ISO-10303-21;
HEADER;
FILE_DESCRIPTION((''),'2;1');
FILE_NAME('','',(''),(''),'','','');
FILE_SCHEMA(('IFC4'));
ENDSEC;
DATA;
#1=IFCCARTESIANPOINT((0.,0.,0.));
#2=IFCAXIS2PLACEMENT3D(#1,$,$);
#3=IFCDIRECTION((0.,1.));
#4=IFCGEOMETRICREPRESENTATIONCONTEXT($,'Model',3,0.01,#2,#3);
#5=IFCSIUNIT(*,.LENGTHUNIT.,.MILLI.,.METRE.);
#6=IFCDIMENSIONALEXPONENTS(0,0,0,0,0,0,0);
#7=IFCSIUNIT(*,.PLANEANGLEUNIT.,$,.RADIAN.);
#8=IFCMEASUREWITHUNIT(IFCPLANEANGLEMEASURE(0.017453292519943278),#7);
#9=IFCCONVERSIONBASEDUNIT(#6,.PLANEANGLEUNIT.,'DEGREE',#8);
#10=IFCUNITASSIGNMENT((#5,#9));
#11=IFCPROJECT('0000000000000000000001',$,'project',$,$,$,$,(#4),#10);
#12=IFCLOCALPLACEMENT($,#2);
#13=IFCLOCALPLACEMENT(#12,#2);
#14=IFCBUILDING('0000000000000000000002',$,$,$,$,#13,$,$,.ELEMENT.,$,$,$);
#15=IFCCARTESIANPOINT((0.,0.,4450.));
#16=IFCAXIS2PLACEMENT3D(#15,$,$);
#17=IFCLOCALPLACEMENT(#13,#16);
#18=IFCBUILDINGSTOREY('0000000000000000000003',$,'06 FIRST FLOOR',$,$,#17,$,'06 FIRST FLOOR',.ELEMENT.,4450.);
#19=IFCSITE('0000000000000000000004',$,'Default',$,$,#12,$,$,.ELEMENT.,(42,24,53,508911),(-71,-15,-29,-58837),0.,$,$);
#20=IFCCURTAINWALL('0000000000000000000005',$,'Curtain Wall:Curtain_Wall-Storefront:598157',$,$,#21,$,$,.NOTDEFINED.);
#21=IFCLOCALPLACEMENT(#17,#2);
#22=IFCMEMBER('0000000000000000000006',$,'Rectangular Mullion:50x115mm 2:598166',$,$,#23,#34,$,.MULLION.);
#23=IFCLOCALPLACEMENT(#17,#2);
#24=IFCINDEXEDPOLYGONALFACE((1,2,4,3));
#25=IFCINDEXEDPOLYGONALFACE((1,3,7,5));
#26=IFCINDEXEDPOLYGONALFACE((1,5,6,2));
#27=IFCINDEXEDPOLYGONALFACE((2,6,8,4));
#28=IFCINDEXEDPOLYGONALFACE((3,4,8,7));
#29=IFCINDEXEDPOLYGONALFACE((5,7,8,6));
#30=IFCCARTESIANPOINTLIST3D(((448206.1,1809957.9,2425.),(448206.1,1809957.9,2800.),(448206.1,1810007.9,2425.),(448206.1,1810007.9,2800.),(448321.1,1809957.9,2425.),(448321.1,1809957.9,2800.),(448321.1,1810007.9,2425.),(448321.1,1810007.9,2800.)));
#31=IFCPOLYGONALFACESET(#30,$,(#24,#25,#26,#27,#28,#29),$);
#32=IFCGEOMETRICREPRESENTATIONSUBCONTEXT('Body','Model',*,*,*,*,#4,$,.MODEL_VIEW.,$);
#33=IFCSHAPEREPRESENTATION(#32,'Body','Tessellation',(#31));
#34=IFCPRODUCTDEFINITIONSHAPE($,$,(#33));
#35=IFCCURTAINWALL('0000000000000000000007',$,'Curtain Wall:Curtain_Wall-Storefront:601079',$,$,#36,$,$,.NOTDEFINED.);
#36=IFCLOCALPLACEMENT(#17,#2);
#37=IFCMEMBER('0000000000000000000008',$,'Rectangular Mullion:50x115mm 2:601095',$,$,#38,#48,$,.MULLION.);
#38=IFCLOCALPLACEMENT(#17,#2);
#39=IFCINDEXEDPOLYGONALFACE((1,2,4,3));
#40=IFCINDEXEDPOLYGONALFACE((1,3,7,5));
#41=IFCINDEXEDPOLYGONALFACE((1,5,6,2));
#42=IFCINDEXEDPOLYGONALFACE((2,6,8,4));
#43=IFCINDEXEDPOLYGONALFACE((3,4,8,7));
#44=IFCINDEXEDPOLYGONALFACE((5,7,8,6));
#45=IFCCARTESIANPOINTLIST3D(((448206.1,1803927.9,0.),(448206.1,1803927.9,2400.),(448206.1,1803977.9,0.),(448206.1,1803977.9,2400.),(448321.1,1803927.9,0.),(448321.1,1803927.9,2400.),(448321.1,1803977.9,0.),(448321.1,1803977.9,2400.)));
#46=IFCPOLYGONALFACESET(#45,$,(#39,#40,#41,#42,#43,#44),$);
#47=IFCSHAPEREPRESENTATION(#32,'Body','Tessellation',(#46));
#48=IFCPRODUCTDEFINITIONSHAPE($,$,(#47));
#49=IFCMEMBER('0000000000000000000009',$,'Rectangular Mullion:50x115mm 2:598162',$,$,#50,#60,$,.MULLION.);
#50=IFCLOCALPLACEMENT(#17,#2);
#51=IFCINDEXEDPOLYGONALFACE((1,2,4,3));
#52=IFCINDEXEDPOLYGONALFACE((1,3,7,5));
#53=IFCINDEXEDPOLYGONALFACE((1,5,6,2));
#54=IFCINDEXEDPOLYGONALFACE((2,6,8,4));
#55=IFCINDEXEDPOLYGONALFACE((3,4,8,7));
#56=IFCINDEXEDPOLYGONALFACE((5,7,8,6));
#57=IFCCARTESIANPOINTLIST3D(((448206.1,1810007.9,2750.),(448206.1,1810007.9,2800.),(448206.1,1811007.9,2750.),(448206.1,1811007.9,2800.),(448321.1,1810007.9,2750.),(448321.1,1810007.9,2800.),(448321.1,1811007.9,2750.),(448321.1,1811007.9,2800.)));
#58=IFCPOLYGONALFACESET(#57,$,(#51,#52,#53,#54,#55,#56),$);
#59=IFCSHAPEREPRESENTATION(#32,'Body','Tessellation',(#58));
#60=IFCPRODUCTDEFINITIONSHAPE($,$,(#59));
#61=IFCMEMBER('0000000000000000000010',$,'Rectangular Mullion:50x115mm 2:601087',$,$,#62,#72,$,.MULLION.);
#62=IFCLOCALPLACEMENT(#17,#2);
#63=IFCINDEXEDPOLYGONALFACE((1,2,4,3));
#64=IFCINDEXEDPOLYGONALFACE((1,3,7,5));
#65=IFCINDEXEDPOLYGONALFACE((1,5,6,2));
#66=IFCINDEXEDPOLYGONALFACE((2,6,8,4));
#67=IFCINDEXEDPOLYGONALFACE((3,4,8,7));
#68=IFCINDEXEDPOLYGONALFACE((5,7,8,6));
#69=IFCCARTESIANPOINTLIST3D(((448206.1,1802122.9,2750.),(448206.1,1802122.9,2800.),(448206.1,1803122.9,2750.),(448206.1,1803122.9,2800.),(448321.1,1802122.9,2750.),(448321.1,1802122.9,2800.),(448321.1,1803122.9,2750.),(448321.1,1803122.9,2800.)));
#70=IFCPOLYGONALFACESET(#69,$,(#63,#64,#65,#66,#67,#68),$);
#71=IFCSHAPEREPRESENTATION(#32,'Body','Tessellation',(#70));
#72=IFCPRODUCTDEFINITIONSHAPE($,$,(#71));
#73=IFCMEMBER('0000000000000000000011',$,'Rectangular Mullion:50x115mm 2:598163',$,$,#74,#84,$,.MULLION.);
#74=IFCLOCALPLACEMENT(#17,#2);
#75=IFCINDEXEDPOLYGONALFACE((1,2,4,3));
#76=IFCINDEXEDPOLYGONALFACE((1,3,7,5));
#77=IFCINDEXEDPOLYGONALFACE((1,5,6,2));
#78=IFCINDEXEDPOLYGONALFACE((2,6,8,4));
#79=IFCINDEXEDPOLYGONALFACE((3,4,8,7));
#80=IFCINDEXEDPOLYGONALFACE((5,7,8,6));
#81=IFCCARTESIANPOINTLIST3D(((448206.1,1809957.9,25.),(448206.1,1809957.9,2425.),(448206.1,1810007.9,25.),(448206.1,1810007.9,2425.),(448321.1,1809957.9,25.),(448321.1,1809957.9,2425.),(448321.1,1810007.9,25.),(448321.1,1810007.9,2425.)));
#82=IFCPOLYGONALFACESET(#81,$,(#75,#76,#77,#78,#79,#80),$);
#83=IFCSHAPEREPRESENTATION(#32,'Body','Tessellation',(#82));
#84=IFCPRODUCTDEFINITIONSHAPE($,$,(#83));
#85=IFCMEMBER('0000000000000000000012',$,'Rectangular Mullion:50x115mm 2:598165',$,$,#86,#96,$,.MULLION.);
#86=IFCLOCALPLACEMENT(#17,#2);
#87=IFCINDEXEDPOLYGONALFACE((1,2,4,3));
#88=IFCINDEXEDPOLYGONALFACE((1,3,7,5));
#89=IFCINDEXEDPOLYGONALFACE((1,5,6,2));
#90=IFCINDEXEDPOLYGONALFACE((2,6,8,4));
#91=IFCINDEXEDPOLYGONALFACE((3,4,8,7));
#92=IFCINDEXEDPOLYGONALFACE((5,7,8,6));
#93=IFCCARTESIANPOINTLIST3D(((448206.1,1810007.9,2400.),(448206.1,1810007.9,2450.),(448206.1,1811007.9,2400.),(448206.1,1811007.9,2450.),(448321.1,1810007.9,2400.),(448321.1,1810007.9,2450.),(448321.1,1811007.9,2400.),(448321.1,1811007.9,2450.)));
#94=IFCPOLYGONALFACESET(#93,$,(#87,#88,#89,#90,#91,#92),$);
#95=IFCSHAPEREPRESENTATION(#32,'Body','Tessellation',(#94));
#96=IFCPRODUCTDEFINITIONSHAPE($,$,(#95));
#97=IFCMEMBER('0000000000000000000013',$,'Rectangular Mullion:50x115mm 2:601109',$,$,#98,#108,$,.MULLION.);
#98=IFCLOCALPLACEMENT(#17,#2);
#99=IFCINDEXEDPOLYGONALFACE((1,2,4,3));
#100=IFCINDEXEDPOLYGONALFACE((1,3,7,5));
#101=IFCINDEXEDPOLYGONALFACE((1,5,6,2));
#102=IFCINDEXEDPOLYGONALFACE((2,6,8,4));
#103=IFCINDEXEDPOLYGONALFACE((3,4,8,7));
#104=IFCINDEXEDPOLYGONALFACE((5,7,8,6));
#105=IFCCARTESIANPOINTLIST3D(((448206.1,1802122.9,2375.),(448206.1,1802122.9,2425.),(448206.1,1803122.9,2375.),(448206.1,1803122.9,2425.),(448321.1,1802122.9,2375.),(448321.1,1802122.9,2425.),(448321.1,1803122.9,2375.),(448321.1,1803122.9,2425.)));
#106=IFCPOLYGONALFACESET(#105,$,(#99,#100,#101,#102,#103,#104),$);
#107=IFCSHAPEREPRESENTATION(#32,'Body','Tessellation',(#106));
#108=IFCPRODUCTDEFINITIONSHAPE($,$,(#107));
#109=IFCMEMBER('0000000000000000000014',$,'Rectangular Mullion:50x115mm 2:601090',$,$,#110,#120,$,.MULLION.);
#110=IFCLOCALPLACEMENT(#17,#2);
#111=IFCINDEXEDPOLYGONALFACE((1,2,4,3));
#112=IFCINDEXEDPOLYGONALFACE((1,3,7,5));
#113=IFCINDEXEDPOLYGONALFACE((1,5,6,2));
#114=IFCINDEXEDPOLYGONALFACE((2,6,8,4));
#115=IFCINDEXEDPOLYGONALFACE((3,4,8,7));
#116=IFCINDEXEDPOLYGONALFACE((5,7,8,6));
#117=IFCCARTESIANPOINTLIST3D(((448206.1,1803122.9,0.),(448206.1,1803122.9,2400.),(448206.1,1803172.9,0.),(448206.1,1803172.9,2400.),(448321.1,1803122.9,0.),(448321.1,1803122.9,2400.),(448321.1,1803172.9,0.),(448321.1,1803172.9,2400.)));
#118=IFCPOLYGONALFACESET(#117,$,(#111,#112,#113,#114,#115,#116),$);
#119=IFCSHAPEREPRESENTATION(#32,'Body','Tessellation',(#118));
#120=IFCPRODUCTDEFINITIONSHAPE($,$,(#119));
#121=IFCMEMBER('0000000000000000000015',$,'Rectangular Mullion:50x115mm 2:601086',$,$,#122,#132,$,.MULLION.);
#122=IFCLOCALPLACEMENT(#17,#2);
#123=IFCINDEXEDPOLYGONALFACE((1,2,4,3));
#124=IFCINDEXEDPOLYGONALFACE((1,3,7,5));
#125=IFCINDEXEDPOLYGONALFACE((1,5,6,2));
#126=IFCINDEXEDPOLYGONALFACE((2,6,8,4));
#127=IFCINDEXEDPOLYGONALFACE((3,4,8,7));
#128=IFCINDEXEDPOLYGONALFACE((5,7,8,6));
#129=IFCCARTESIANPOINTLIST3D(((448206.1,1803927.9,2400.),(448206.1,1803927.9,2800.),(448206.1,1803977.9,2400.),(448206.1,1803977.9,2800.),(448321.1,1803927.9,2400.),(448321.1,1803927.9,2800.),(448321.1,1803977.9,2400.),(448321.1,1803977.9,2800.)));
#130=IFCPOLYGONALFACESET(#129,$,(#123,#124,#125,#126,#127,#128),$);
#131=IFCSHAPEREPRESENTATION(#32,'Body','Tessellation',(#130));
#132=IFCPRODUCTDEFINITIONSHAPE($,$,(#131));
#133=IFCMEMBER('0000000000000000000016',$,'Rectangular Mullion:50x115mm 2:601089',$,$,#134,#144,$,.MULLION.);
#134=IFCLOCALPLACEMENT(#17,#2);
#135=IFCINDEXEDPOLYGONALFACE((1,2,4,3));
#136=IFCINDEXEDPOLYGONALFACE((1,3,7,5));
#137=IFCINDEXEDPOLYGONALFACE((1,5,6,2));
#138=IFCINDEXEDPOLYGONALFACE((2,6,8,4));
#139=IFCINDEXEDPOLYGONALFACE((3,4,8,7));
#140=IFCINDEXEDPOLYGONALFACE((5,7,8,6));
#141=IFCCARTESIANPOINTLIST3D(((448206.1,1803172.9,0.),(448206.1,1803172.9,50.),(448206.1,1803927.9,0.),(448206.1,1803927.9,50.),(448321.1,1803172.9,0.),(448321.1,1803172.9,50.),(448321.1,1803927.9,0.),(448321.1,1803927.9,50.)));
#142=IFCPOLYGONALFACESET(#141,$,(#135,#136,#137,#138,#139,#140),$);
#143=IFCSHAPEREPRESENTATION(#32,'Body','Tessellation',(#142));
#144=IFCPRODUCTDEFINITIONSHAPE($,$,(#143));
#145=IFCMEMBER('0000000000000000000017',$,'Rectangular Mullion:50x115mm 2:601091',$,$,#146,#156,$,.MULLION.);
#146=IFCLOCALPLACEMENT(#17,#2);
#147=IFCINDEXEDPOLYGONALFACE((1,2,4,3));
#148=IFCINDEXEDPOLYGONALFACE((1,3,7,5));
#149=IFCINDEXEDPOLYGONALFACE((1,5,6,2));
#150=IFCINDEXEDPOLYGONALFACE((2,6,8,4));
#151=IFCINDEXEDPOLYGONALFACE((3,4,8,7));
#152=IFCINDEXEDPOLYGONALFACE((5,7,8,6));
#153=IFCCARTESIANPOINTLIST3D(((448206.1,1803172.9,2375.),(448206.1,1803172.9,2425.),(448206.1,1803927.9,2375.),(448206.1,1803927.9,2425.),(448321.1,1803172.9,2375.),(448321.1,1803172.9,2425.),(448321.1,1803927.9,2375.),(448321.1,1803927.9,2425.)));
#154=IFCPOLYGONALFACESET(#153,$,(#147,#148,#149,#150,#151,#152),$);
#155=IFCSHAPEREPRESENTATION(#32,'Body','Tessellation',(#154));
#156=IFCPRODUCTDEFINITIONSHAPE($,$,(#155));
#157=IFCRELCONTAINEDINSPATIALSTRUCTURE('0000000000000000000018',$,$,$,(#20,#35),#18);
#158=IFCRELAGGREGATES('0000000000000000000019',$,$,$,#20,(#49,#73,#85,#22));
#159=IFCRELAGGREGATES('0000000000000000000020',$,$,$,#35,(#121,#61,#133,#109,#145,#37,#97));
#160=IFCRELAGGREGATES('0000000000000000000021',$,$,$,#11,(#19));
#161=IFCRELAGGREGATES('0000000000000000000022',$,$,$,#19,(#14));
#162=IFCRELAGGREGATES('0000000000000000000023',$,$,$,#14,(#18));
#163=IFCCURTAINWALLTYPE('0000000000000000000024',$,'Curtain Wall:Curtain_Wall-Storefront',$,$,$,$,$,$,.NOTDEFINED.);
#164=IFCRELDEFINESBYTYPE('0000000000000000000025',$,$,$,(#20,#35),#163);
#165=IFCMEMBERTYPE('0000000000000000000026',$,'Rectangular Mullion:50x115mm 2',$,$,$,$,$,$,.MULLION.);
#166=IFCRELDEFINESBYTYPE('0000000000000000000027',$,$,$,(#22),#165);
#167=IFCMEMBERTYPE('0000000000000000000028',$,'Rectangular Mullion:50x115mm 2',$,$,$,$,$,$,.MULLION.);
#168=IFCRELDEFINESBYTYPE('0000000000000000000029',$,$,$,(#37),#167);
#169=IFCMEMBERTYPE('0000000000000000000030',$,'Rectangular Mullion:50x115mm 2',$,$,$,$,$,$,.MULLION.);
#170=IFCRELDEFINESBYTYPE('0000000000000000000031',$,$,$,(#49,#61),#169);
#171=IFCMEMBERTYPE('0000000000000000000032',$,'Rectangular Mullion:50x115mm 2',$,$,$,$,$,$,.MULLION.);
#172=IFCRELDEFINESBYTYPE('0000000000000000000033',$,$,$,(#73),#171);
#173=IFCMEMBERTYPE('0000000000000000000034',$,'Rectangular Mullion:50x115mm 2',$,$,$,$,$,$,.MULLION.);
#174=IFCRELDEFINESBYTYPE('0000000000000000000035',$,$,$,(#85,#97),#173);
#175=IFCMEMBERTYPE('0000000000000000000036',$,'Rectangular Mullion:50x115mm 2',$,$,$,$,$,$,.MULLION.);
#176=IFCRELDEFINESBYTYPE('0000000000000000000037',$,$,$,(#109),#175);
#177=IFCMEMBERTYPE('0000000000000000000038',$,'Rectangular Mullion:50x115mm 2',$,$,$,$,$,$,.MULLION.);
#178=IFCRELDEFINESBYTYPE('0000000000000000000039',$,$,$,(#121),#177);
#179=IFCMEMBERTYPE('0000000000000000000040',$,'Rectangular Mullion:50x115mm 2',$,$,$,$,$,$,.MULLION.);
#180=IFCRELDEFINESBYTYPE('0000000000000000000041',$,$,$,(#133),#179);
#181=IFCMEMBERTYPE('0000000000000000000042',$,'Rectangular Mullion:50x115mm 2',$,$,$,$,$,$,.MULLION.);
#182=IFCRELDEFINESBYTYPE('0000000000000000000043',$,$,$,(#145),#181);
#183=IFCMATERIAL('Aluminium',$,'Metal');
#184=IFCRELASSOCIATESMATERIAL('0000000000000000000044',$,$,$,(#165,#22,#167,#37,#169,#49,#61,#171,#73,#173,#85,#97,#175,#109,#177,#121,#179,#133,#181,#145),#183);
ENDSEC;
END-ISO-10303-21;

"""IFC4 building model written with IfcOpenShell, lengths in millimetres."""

from ifc_helpers import new_model, entity, si_unit, converted_unit, direction, frame, origin, place, context, subcontext, project, spatial, indexed_curve, outline, extrude, source, transform, mapped, material, type_object, type_shapes, element, aggregate, save


model = new_model("IFC4")

# Units and contexts
model_context = context("Model", 3, precision=0.01, world=origin(), true_north=direction((0.0, 1.0)))
body_context = subcontext(model_context, "Body", "Model", "MODEL_VIEW")
ifc_project = project(units=[si_unit("LENGTHUNIT", "METRE", prefix="MILLI"), converted_unit("PLANEANGLEUNIT", "DEGREE", entity("IfcPlaneAngleMeasure", 0.017453292519943278), si_unit("PLANEANGLEUNIT", "RADIAN"), dimensions=[0, 0, 0, 0, 0, 0, 0])], contexts=[model_context])

# Site, building, storey
site_placement = place(None, origin())
site = spatial("IfcSite", under=ifc_project, at=site_placement, Name="Default", CompositionType="ELEMENT", RefLatitude=(42, 24, 53, 508911), RefLongitude=(-71, -15, -29, -58837), RefElevation=0.0)
building_placement = place(site_placement, origin())
building = spatial("IfcBuilding", under=site, at=building_placement, CompositionType="ELEMENT")
storey_placement = place(building_placement, frame((0.0, 0.0, 4450.0)))
storey = spatial("IfcBuildingStorey", under=building, at=storey_placement, Name="06 FIRST FLOOR", LongName="06 FIRST FLOOR", CompositionType="ELEMENT", Elevation=4450.0)

# Curtain walls, members
curtain_wall_type = type_object("IfcCurtainWallType", Name="Curtain Wall:Curtain_Wall-Storefront", PredefinedType="NOTDEFINED")
curtain_wall_1_placement = place(storey_placement, frame((0.0, 0.0, -4450.0)))
curtain_wall_1 = element("IfcCurtainWall", 1, at=curtain_wall_1_placement, inside=storey, type_object=curtain_wall_type, Name="Curtain Wall:Curtain_Wall-Storefront:598157", PredefinedType="NOTDEFINED")
ifc_material_1 = material(Name="Aluminium", Category="Metal")
member_type_1 = type_object("IfcMemberType", Name="Rectangular Mullion:50x115mm 2", PredefinedType="MULLION", material=ifc_material_1)
shared_shape_1 = source(origin(), body_context, "Body", "SweptSolid", [
    extrude(outline(indexed_curve([(-25.0, -57.5), (25.0, -57.5), (25.0, 57.5), (-25.0, 57.5), (-25.0, -57.5)], self_intersect=False)), frame((-25.0, 0.0, -375.0), z_axis=(0.0, 0.0, 1.0), x_axis=(-1.0, 0.0, 0.0)), (0.0, 0.0, 1.0), 375.0),
])
type_shapes(member_type_1, [shared_shape_1])
member_1_placement = place(curtain_wall_1_placement, frame((448263.6, 1809957.9, 6875.0), z_axis=(0.0, 0.0, -1.0), x_axis=(0.0, -1.0, 0.0)))
member_1 = element("IfcMember", 2, at=member_1_placement, type_object=member_type_1, material=ifc_material_1, Name="Rectangular Mullion:50x115mm 2:598166", PredefinedType="MULLION", context=body_context, shape_type="MappedRepresentation", body=[
    mapped(shared_shape_1, transform((0.0, 0.0, 0.0), scale=1.0)),
])
curtain_wall_2_placement = place(storey_placement, frame((0.0, 0.0, -4450.0)))
curtain_wall_2 = element("IfcCurtainWall", 3, at=curtain_wall_2_placement, inside=storey, type_object=curtain_wall_type, Name="Curtain Wall:Curtain_Wall-Storefront:601079", PredefinedType="NOTDEFINED")
member_type_2 = type_object("IfcMemberType", Name="Rectangular Mullion:50x115mm 2", PredefinedType="MULLION", material=ifc_material_1)
shared_shape_2 = source(origin(), body_context, "Body", "SweptSolid", [
    extrude(outline(indexed_curve([(-25.0, -57.5), (25.0, -57.5), (25.0, 57.5), (-25.0, 57.5), (-25.0, -57.5)], self_intersect=False)), frame((-25.0, 0.0, -2400.0), z_axis=(0.0, 0.0, 1.0), x_axis=(-1.0, 0.0, 0.0)), (0.0, 0.0, 1.0), 2400.0),
])
type_shapes(member_type_2, [shared_shape_2])
member_2_placement = place(curtain_wall_2_placement, frame((448263.6, 1803977.9, 6850.0), z_axis=(0.0, 0.0, 1.0), x_axis=(0.0, 1.0, 0.0)))
member_2 = element("IfcMember", 4, at=member_2_placement, type_object=member_type_2, material=ifc_material_1, Name="Rectangular Mullion:50x115mm 2:601095", PredefinedType="MULLION", context=body_context, shape_type="MappedRepresentation", body=[
    mapped(shared_shape_2, transform((0.0, 0.0, 0.0), scale=1.0)),
])

# Members
member_type_3 = type_object("IfcMemberType", Name="Rectangular Mullion:50x115mm 2", PredefinedType="MULLION", material=ifc_material_1)
shared_shape_3 = source(origin(), body_context, "Body", "SweptSolid", [
    extrude(outline(indexed_curve([(-25.0, -57.5), (25.0, -57.5), (25.0, 57.5), (-25.0, 57.5), (-25.0, -57.5)], self_intersect=False)), frame((-25.0, 0.0, -1000.0), z_axis=(0.0, 0.0, 1.0), x_axis=(-1.0, 0.0, 0.0)), (0.0, 0.0, 1.0), 1000.0),
])
type_shapes(member_type_3, [shared_shape_3])
member_3_placement = place(curtain_wall_1_placement, frame((448263.6, 1810007.9, 7250.0), z_axis=(0.0, -1.0, 0.0), x_axis=(0.0, 0.0, 1.0)))
member_3 = element("IfcMember", 5, at=member_3_placement, type_object=member_type_3, material=ifc_material_1, Name="Rectangular Mullion:50x115mm 2:598162", PredefinedType="MULLION", context=body_context, shape_type="MappedRepresentation", body=[
    mapped(shared_shape_3, transform((0.0, 0.0, 0.0), scale=1.0)),
])
member_4_placement = place(curtain_wall_2_placement, frame((448263.6, 1802122.9, 7250.0), z_axis=(0.0, -1.0, 0.0), x_axis=(0.0, 0.0, 1.0)))
member_4 = element("IfcMember", 6, at=member_4_placement, type_object=member_type_3, material=ifc_material_1, Name="Rectangular Mullion:50x115mm 2:601087", PredefinedType="MULLION", context=body_context, shape_type="MappedRepresentation", body=[
    mapped(shared_shape_3, transform((0.0, 0.0, 0.0), scale=1.0)),
])
member_type_4 = type_object("IfcMemberType", Name="Rectangular Mullion:50x115mm 2", PredefinedType="MULLION", material=ifc_material_1)
shared_shape_4 = source(origin(), body_context, "Body", "SweptSolid", [
    extrude(outline(indexed_curve([(-25.0, -57.5), (25.0, -57.5), (25.0, 57.5), (-25.0, 57.5), (-25.0, -57.5)], self_intersect=False)), frame((-25.0, 0.0, -2400.0), z_axis=(0.0, 0.0, 1.0), x_axis=(-1.0, 0.0, 0.0)), (0.0, 0.0, 1.0), 2400.0),
])
type_shapes(member_type_4, [shared_shape_4])
member_5_placement = place(curtain_wall_1_placement, frame((448263.6, 1809957.9, 4475.0), z_axis=(0.0, 0.0, -1.0), x_axis=(0.0, -1.0, 0.0)))
member_5 = element("IfcMember", 7, at=member_5_placement, type_object=member_type_4, material=ifc_material_1, Name="Rectangular Mullion:50x115mm 2:598163", PredefinedType="MULLION", context=body_context, shape_type="MappedRepresentation", body=[
    mapped(shared_shape_4, transform((0.0, 0.0, 0.0), scale=1.0)),
])
member_type_5 = type_object("IfcMemberType", Name="Rectangular Mullion:50x115mm 2", PredefinedType="MULLION", material=ifc_material_1)
shared_shape_5 = source(origin(), body_context, "Body", "SweptSolid", [
    extrude(outline(indexed_curve([(-25.0, -57.5), (25.0, -57.5), (25.0, 57.5), (-25.0, 57.5), (-25.0, -57.5)], self_intersect=False)), frame((0.0, 0.0, -1000.0), z_axis=(0.0, 0.0, 1.0), x_axis=(-1.0, 0.0, 0.0)), (0.0, 0.0, 1.0), 1000.0),
])
type_shapes(member_type_5, [shared_shape_5])
member_6_placement = place(curtain_wall_1_placement, frame((448263.6, 1810007.9, 6875.0), z_axis=(0.0, -1.0, 0.0), x_axis=(0.0, 0.0, 1.0)))
member_6 = element("IfcMember", 8, at=member_6_placement, type_object=member_type_5, material=ifc_material_1, Name="Rectangular Mullion:50x115mm 2:598165", PredefinedType="MULLION", context=body_context, shape_type="MappedRepresentation", body=[
    mapped(shared_shape_5, transform((0.0, 0.0, 0.0), scale=1.0)),
])
member_7_placement = place(curtain_wall_2_placement, frame((448263.6, 1802122.9, 6850.0), z_axis=(0.0, -1.0, 0.0), x_axis=(0.0, 0.0, 1.0)))
member_7 = element("IfcMember", 9, at=member_7_placement, type_object=member_type_5, material=ifc_material_1, Name="Rectangular Mullion:50x115mm 2:601109", PredefinedType="MULLION", context=body_context, shape_type="MappedRepresentation", body=[
    mapped(shared_shape_5, transform((0.0, 0.0, 0.0), scale=1.0)),
])
member_type_6 = type_object("IfcMemberType", Name="Rectangular Mullion:50x115mm 2", PredefinedType="MULLION", material=ifc_material_1)
shared_shape_6 = source(origin(), body_context, "Body", "SweptSolid", [
    extrude(outline(indexed_curve([(-25.0, -57.5), (25.0, -57.5), (25.0, 57.5), (-25.0, 57.5), (-25.0, -57.5)], self_intersect=False)), frame((0.0, 0.0, -2400.0), z_axis=(0.0, 0.0, 1.0), x_axis=(-1.0, 0.0, 0.0)), (0.0, 0.0, 1.0), 2400.0),
])
type_shapes(member_type_6, [shared_shape_6])
member_8_placement = place(curtain_wall_2_placement, frame((448263.6, 1803147.9, 4450.0), z_axis=(0.0, 0.0, -1.0), x_axis=(0.0, -1.0, 0.0)))
member_8 = element("IfcMember", 10, at=member_8_placement, type_object=member_type_6, material=ifc_material_1, Name="Rectangular Mullion:50x115mm 2:601090", PredefinedType="MULLION", context=body_context, shape_type="MappedRepresentation", body=[
    mapped(shared_shape_6, transform((0.0, 0.0, 0.0), scale=1.0)),
])
member_type_7 = type_object("IfcMemberType", Name="Rectangular Mullion:50x115mm 2", PredefinedType="MULLION", material=ifc_material_1)
shared_shape_7 = source(origin(), body_context, "Body", "SweptSolid", [
    extrude(outline(indexed_curve([(-25.0, -57.5), (25.0, -57.5), (25.0, 57.5), (-25.0, 57.5), (-25.0, -57.5)], self_intersect=False)), frame((-25.0, 0.0, -400.0), z_axis=(0.0, 0.0, 1.0), x_axis=(-1.0, 0.0, 0.0)), (0.0, 0.0, 1.0), 400.0),
])
type_shapes(member_type_7, [shared_shape_7])
member_9_placement = place(curtain_wall_2_placement, frame((448263.6, 1803977.9, 7250.0), z_axis=(0.0, 0.0, 1.0), x_axis=(0.0, 1.0, 0.0)))
member_9 = element("IfcMember", 11, at=member_9_placement, type_object=member_type_7, material=ifc_material_1, Name="Rectangular Mullion:50x115mm 2:601086", PredefinedType="MULLION", context=body_context, shape_type="MappedRepresentation", body=[
    mapped(shared_shape_7, transform((0.0, 0.0, 0.0), scale=1.0)),
])
member_type_8 = type_object("IfcMemberType", Name="Rectangular Mullion:50x115mm 2", PredefinedType="MULLION", material=ifc_material_1)
shared_shape_8 = source(origin(), body_context, "Body", "SweptSolid", [
    extrude(outline(indexed_curve([(-25.0, -57.5), (25.0, -57.5), (25.0, 57.5), (-25.0, 57.5), (-25.0, -57.5)], self_intersect=False)), frame((-25.0, 0.0, -755.0), z_axis=(0.0, 0.0, 1.0), x_axis=(-1.0, 0.0, 0.0)), (0.0, 0.0, 1.0), 755.0),
])
type_shapes(member_type_8, [shared_shape_8])
member_10_placement = place(curtain_wall_2_placement, frame((448263.6, 1803927.9, 4450.0), z_axis=(0.0, 1.0, 0.0), x_axis=(0.0, 0.0, -1.0)))
member_10 = element("IfcMember", 12, at=member_10_placement, type_object=member_type_8, material=ifc_material_1, Name="Rectangular Mullion:50x115mm 2:601089", PredefinedType="MULLION", context=body_context, shape_type="MappedRepresentation", body=[
    mapped(shared_shape_8, transform((0.0, 0.0, 0.0), scale=1.0)),
])
member_type_9 = type_object("IfcMemberType", Name="Rectangular Mullion:50x115mm 2", PredefinedType="MULLION", material=ifc_material_1)
shared_shape_9 = source(origin(), body_context, "Body", "SweptSolid", [
    extrude(outline(indexed_curve([(-25.0, -57.5), (25.0, -57.5), (25.0, 57.5), (-25.0, 57.5), (-25.0, -57.5)], self_intersect=False)), frame((0.0, 0.0, -755.0), z_axis=(0.0, 0.0, 1.0), x_axis=(-1.0, 0.0, 0.0)), (0.0, 0.0, 1.0), 755.0),
])
type_shapes(member_type_9, [shared_shape_9])
member_11_placement = place(curtain_wall_2_placement, frame((448263.6, 1803172.9, 6850.0), z_axis=(0.0, -1.0, 0.0), x_axis=(0.0, 0.0, 1.0)))
member_11 = element("IfcMember", 13, at=member_11_placement, type_object=member_type_9, material=ifc_material_1, Name="Rectangular Mullion:50x115mm 2:601091", PredefinedType="MULLION", context=body_context, shape_type="MappedRepresentation", body=[
    mapped(shared_shape_9, transform((0.0, 0.0, 0.0), scale=1.0)),
])

aggregate(curtain_wall_1, [member_3, member_5, member_6, member_1])
aggregate(curtain_wall_2, [member_9, member_4, member_10, member_8, member_11, member_2, member_7])

save(model, "model.ifc")
